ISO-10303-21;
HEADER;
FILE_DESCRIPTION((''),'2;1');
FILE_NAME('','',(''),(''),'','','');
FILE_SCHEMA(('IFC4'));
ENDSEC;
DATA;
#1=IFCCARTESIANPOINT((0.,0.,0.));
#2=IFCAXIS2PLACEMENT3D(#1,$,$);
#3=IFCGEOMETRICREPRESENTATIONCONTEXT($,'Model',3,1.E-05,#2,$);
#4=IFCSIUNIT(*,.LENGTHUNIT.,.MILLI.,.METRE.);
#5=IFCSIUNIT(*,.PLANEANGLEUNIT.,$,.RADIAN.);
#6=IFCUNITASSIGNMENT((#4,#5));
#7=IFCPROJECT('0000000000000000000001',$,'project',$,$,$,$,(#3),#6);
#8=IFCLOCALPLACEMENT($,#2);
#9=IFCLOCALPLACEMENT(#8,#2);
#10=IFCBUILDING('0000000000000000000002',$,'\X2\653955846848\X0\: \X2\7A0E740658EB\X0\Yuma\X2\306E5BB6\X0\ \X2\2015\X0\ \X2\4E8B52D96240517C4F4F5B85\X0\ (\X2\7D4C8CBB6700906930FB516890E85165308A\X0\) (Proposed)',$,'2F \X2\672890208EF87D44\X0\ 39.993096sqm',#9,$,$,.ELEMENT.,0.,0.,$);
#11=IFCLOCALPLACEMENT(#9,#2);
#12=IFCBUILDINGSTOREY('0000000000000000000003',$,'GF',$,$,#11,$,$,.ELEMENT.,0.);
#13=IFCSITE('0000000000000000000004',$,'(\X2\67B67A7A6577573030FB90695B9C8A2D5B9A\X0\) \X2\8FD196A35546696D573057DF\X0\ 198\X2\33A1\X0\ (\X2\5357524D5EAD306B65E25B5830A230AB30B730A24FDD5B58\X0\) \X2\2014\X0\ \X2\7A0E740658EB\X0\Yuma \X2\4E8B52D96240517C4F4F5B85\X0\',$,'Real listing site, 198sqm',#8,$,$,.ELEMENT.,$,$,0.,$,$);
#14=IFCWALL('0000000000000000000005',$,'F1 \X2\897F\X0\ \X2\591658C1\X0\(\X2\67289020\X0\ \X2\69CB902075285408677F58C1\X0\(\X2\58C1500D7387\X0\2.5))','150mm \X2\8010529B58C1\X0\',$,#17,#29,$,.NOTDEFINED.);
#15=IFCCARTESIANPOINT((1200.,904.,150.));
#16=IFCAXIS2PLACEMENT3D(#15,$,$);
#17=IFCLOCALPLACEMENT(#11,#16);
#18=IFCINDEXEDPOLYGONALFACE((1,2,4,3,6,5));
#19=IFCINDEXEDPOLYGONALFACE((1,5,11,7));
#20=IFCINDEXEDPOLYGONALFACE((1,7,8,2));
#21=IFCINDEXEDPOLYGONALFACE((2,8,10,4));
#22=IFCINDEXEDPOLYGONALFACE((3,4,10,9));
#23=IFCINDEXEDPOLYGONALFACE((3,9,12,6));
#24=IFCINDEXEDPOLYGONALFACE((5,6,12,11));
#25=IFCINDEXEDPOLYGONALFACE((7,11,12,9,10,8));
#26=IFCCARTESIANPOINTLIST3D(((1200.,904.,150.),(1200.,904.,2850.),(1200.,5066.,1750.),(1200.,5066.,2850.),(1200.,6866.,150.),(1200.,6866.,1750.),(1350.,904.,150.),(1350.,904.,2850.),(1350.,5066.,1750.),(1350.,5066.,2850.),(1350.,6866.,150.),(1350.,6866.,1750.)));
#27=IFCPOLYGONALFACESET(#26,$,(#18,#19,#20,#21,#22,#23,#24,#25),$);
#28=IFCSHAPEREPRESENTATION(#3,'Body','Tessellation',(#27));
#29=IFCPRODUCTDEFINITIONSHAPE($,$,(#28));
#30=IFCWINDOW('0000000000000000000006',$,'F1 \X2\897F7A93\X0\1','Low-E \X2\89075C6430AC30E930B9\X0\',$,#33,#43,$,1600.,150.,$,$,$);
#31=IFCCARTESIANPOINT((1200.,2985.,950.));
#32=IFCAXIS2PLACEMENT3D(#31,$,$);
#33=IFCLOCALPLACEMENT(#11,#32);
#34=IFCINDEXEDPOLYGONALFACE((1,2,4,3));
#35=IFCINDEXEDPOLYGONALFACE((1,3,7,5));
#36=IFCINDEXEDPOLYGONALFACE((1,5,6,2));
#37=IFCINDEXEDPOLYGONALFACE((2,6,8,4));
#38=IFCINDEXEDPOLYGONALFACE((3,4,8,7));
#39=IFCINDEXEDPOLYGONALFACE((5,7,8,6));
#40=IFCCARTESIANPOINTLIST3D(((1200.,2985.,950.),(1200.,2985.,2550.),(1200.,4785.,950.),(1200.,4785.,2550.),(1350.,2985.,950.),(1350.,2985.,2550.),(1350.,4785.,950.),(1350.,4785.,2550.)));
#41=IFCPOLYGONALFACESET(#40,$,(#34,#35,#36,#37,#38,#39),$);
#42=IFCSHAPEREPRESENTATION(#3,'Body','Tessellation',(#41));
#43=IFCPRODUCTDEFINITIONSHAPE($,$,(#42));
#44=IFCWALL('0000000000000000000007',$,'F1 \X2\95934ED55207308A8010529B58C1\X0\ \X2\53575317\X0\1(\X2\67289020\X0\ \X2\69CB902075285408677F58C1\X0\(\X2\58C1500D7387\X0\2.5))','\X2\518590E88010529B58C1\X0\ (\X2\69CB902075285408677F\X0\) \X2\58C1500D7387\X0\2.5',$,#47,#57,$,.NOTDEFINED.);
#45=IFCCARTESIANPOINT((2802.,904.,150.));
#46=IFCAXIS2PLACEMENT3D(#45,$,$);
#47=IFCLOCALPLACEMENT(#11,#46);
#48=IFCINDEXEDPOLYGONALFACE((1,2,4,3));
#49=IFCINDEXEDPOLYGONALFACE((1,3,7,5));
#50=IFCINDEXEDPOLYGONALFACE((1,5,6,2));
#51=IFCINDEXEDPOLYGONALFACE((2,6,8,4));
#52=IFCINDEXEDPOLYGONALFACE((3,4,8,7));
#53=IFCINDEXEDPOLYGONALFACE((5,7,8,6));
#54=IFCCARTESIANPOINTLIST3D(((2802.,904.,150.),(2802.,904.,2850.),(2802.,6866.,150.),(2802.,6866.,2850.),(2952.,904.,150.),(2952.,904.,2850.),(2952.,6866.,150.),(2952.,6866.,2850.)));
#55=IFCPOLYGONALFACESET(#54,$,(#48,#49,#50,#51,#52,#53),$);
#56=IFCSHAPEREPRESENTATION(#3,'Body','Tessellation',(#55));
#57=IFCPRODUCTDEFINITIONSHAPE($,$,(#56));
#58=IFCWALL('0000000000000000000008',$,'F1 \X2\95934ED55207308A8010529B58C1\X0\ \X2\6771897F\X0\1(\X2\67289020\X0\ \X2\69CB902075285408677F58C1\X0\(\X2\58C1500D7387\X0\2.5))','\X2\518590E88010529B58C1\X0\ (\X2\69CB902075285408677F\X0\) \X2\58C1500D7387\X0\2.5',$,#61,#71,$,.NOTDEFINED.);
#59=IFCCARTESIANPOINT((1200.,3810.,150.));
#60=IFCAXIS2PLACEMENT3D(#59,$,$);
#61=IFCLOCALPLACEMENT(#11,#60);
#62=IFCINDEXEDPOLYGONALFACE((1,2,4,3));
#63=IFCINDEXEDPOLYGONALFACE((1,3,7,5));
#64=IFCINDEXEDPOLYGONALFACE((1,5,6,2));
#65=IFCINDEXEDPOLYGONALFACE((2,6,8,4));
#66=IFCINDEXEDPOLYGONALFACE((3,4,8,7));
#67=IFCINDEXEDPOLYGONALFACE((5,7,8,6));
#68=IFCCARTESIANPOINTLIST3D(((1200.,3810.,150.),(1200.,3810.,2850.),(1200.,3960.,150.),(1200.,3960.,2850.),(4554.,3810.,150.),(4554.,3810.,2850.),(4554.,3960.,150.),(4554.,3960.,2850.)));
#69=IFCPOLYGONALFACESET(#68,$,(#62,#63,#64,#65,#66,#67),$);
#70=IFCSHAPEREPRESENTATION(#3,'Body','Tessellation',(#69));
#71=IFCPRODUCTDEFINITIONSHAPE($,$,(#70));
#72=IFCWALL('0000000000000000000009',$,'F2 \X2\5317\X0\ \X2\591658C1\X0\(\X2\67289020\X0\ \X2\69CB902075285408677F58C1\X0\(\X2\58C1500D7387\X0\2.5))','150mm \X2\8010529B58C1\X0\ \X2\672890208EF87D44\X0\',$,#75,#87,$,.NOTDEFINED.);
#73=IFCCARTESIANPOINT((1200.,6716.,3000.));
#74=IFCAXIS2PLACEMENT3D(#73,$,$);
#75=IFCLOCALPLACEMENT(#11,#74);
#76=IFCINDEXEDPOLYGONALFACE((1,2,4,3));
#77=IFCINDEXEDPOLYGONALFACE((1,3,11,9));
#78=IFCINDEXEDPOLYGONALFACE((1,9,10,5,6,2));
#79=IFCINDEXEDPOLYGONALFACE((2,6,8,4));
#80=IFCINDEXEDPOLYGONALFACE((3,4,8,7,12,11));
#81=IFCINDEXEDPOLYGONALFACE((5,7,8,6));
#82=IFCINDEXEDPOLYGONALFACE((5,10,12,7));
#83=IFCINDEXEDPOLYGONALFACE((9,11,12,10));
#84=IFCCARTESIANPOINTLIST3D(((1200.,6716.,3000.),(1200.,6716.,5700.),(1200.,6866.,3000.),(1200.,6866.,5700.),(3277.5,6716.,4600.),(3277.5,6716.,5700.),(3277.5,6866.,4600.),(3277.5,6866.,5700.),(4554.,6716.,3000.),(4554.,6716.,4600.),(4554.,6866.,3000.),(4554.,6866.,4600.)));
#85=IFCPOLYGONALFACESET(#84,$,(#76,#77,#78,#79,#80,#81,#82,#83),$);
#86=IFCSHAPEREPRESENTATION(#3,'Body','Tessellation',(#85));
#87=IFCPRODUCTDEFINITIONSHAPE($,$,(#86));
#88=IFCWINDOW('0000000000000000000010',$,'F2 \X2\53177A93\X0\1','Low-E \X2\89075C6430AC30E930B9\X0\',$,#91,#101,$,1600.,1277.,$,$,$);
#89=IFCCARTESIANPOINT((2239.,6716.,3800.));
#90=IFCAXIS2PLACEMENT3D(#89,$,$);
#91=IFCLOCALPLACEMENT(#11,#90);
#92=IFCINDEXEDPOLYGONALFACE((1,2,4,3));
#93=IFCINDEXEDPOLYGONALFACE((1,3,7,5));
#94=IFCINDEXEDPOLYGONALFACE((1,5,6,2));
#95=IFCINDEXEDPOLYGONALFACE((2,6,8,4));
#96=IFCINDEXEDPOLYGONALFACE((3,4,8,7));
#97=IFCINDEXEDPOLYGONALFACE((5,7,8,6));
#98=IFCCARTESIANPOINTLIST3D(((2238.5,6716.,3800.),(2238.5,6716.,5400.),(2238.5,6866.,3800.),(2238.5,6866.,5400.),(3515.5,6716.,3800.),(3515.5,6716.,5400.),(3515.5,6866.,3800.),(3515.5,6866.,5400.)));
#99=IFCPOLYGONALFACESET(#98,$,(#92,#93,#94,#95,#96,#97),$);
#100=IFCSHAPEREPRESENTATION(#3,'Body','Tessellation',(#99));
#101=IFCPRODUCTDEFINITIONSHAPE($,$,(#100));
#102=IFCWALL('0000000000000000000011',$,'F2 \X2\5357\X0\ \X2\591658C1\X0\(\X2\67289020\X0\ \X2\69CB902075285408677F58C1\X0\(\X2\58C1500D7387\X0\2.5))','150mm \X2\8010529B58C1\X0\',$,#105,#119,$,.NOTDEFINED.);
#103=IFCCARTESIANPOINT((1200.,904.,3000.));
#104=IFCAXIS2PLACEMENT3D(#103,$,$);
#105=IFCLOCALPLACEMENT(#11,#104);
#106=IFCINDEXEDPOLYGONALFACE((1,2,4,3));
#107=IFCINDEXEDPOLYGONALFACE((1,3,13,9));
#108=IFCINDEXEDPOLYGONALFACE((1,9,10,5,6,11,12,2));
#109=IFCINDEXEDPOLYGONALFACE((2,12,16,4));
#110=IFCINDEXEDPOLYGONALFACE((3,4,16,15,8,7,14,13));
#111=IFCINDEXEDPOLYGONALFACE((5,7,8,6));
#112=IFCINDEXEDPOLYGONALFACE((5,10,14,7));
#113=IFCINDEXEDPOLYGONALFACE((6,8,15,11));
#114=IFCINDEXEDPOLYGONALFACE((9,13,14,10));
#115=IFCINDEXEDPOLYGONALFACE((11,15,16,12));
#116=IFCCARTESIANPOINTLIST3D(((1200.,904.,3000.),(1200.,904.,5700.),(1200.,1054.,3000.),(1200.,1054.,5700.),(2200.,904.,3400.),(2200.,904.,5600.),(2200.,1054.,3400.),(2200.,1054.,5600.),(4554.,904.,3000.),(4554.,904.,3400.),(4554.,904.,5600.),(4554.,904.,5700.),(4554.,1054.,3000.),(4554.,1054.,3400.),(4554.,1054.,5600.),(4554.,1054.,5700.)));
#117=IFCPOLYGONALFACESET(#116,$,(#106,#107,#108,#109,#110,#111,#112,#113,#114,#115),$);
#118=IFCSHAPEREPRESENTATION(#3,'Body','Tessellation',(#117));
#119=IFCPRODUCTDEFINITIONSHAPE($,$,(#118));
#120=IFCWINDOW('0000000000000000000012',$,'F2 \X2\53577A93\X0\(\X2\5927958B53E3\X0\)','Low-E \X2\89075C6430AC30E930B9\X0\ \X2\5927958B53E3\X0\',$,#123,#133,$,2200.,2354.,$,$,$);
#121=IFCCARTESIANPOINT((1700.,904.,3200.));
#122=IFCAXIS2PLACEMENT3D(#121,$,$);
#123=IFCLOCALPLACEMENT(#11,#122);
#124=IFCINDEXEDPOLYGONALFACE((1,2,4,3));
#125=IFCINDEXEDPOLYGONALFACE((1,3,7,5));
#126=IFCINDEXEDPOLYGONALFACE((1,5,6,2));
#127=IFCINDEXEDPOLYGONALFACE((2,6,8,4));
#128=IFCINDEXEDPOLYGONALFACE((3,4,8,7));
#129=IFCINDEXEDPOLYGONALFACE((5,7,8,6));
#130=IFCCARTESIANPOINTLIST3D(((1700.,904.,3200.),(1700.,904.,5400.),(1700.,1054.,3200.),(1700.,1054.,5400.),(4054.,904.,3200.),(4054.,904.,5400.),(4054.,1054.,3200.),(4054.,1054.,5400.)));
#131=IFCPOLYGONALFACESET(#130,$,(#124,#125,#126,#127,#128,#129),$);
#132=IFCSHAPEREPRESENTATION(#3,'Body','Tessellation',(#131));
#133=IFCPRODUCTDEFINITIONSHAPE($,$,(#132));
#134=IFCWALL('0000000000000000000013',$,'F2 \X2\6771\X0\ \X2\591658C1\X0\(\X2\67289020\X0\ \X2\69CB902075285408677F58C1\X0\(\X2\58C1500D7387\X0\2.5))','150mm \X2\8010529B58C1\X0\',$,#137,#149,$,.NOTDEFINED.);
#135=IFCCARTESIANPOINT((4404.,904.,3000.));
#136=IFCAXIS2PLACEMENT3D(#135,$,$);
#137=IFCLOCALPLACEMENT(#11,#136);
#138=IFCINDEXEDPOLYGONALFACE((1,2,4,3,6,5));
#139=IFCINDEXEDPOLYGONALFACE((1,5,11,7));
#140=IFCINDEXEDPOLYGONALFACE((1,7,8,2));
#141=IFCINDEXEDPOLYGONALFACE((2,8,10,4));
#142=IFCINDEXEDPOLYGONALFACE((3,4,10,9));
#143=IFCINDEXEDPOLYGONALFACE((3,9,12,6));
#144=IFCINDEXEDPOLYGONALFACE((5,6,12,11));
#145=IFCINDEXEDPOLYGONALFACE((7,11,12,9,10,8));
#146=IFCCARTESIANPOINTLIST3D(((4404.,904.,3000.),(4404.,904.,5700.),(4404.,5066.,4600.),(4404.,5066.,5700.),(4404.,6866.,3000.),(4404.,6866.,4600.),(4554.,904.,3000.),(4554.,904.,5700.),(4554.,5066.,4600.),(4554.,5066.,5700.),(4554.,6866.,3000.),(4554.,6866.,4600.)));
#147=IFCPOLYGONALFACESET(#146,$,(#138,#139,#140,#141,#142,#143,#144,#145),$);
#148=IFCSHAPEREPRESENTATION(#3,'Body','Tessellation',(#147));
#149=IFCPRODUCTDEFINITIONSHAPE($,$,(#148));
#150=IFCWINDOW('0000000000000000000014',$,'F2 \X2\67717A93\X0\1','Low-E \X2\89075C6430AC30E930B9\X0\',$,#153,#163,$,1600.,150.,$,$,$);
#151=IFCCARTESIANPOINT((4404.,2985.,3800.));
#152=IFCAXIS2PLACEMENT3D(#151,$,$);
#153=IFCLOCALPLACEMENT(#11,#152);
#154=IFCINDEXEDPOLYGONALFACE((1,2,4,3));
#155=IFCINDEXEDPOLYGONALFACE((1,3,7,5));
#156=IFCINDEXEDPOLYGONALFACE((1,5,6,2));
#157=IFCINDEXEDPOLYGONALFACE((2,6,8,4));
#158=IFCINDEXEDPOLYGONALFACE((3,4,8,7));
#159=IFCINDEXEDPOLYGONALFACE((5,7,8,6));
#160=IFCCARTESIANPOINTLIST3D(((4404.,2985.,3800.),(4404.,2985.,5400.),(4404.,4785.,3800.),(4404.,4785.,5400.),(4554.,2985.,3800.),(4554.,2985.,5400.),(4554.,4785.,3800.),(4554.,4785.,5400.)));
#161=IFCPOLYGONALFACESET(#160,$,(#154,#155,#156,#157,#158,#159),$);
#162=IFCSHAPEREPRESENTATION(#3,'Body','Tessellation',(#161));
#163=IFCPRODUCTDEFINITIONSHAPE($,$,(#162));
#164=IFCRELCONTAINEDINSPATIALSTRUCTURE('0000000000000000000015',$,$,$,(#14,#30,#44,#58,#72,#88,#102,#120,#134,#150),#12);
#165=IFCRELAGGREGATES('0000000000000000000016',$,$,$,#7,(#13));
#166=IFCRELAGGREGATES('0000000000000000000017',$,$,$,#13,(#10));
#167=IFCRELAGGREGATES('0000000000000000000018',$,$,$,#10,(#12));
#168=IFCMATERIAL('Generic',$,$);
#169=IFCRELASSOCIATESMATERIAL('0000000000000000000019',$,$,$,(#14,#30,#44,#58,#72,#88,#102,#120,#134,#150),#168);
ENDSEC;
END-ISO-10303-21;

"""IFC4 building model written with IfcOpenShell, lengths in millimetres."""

from ifc_helpers import new_model, si_unit, frame, frame_2d, origin, place, context, project, spatial, rectangle, extrude, material, element, fill, save


model = new_model("IFC4")

# Units and contexts
model_context = context("Model", 3, precision=1e-05, world=origin())
ifc_project = project(units=[si_unit("LENGTHUNIT", "METRE", prefix="MILLI"), si_unit("PLANEANGLEUNIT", "RADIAN")], contexts=[model_context])

# Site, building, storey
site_placement = place(None, origin())
site = spatial("IfcSite", under=ifc_project, at=site_placement, Name="(架空敷地・適宜設定) 近隣商業地域 198㎡ (南前庭に既存アカシア保存) — 税理士Yuma 事務所兼住宅", ObjectType="Real listing site, 198sqm", CompositionType="ELEMENT", RefElevation=0.0)
building_placement = place(site_placement, origin())
building = spatial("IfcBuilding", under=site, at=building_placement, Name="改善案: 税理士Yumaの家 ― 事務所兼住宅 (経費最適・全部入り) (Proposed)", ObjectType="2F 木造軸組 39.993096sqm", CompositionType="ELEMENT", ElevationOfRefHeight=0.0, ElevationOfTerrain=0.0)
storey_placement = place(building_placement, origin())
storey = spatial("IfcBuildingStorey", under=building, at=storey_placement, Name="GF", CompositionType="ELEMENT", Elevation=0.0)

# Shared definitions
ifc_material_1 = material(Name="Generic")

# Wall, opening, window
wall_1_placement = place(storey_placement, frame((1200.0, 904.0, 150.0)))
wall_1 = element("IfcWall", 1, at=wall_1_placement, inside=storey, material=ifc_material_1, Name="F1 西 外壁(木造 構造用合板壁(壁倍率2.5))", Description="150mm 耐力壁", PredefinedType="NOTDEFINED", context=model_context, shape_type="SweptSolid", body=[
    extrude(rectangle(XDim=150.0, YDim=5962.0, at=frame_2d((75.0, 2981.0))), frame((1200.0, 904.0, 150.0)), (0.0, 0.0, 1.0), 2700.0),
])
opening_1_placement = place(storey_placement, frame((1200.0, 2985.0, 950.0)))
opening_1 = element("IfcOpeningElement", 2, at=opening_1_placement, cuts=wall_1, PredefinedType="NOTDEFINED", context=model_context, shape_type="SweptSolid", body=[
    extrude(rectangle(XDim=150.0, YDim=1800.0, at=frame_2d((75.0, 900.0))), frame((1200.0, 2985.0, 950.0)), (0.0, 0.0, 1.0), 1600.0),
])
window_1_placement = place(storey_placement, frame((1200.0, 2985.0, 950.0)))
window_1 = element("IfcWindow", 3, at=window_1_placement, inside=storey, material=ifc_material_1, Name="F1 西窓1", Description="Low-E 複層ガラス", OverallHeight=1600.0, OverallWidth=150.0, context=model_context, shape_type="SweptSolid", body=[
    extrude(rectangle(XDim=150.0, YDim=1800.0, at=frame_2d((75.0, 900.0))), frame((1200.0, 2985.0, 950.0)), (0.0, 0.0, 1.0), 1600.0),
])
fill(opening_1, window_1)

# Walls
wall_2_placement = place(storey_placement, frame((2802.0, 904.0, 150.0)))
element("IfcWall", 4, at=wall_2_placement, inside=storey, material=ifc_material_1, Name="F1 間仕切り耐力壁 南北1(木造 構造用合板壁(壁倍率2.5))", Description="内部耐力壁 (構造用合板) 壁倍率2.5", PredefinedType="NOTDEFINED", context=model_context, shape_type="SweptSolid", body=[
    extrude(rectangle(XDim=150.0, YDim=5962.0, at=frame_2d((75.0, 2981.0))), frame((2802.0, 904.0, 150.0)), (0.0, 0.0, 1.0), 2700.0),
])
wall_3_placement = place(storey_placement, frame((1200.0, 3810.0, 150.0)))
element("IfcWall", 5, at=wall_3_placement, inside=storey, material=ifc_material_1, Name="F1 間仕切り耐力壁 東西1(木造 構造用合板壁(壁倍率2.5))", Description="内部耐力壁 (構造用合板) 壁倍率2.5", PredefinedType="NOTDEFINED", context=model_context, shape_type="SweptSolid", body=[
    extrude(rectangle(XDim=3354.0, YDim=150.0, at=frame_2d((1677.0, 75.0))), frame((1200.0, 3810.0, 150.0)), (0.0, 0.0, 1.0), 2700.0),
])

# Walls, openings, windows
wall_4_placement = place(storey_placement, frame((1200.0, 6716.0, 3000.0)))
wall_4 = element("IfcWall", 6, at=wall_4_placement, inside=storey, material=ifc_material_1, Name="F2 北 外壁(木造 構造用合板壁(壁倍率2.5))", Description="150mm 耐力壁 木造軸組", PredefinedType="NOTDEFINED", context=model_context, shape_type="SweptSolid", body=[
    extrude(rectangle(XDim=3354.0, YDim=150.0, at=frame_2d((1677.0, 75.0))), frame((1200.0, 6716.0, 3000.0)), (0.0, 0.0, 1.0), 2700.0),
])
opening_2_placement = place(storey_placement, frame((2239.0, 6716.0, 3800.0)))
opening_2 = element("IfcOpeningElement", 7, at=opening_2_placement, cuts=wall_4, PredefinedType="NOTDEFINED", context=model_context, shape_type="SweptSolid", body=[
    extrude(rectangle(XDim=1277.0, YDim=150.0, at=frame_2d((638.0, 75.0))), frame((2239.0, 6716.0, 3800.0)), (0.0, 0.0, 1.0), 1600.0),
])
window_2_placement = place(storey_placement, frame((2239.0, 6716.0, 3800.0)))
window_2 = element("IfcWindow", 8, at=window_2_placement, inside=storey, material=ifc_material_1, Name="F2 北窓1", Description="Low-E 複層ガラス", OverallHeight=1600.0, OverallWidth=1277.0, context=model_context, shape_type="SweptSolid", body=[
    extrude(rectangle(XDim=1277.0, YDim=150.0, at=frame_2d((638.0, 75.0))), frame((2239.0, 6716.0, 3800.0)), (0.0, 0.0, 1.0), 1600.0),
])
fill(opening_2, window_2)
wall_5_placement = place(storey_placement, frame((1200.0, 904.0, 3000.0)))
wall_5 = element("IfcWall", 9, at=wall_5_placement, inside=storey, material=ifc_material_1, Name="F2 南 外壁(木造 構造用合板壁(壁倍率2.5))", Description="150mm 耐力壁", PredefinedType="NOTDEFINED", context=model_context, shape_type="SweptSolid", body=[
    extrude(rectangle(XDim=3354.0, YDim=150.0, at=frame_2d((1677.0, 75.0))), frame((1200.0, 904.0, 3000.0)), (0.0, 0.0, 1.0), 2700.0),
])
opening_3_placement = place(storey_placement, frame((1700.0, 904.0, 3200.0)))
opening_3 = element("IfcOpeningElement", 10, at=opening_3_placement, cuts=wall_5, PredefinedType="NOTDEFINED", context=model_context, shape_type="SweptSolid", body=[
    extrude(rectangle(XDim=2354.0, YDim=150.0, at=frame_2d((1177.0, 75.0))), frame((1700.0, 904.0, 3200.0)), (0.0, 0.0, 1.0), 2200.0),
])
window_3_placement = place(storey_placement, frame((1700.0, 904.0, 3200.0)))
window_3 = element("IfcWindow", 11, at=window_3_placement, inside=storey, material=ifc_material_1, Name="F2 南窓(大開口)", Description="Low-E 複層ガラス 大開口", OverallHeight=2200.0, OverallWidth=2354.0, context=model_context, shape_type="SweptSolid", body=[
    extrude(rectangle(XDim=2354.0, YDim=150.0, at=frame_2d((1177.0, 75.0))), frame((1700.0, 904.0, 3200.0)), (0.0, 0.0, 1.0), 2200.0),
])
fill(opening_3, window_3)
wall_6_placement = place(storey_placement, frame((4404.0, 904.0, 3000.0)))
wall_6 = element("IfcWall", 12, at=wall_6_placement, inside=storey, material=ifc_material_1, Name="F2 東 外壁(木造 構造用合板壁(壁倍率2.5))", Description="150mm 耐力壁", PredefinedType="NOTDEFINED", context=model_context, shape_type="SweptSolid", body=[
    extrude(rectangle(XDim=150.0, YDim=5962.0, at=frame_2d((75.0, 2981.0))), frame((4404.0, 904.0, 3000.0)), (0.0, 0.0, 1.0), 2700.0),
])
opening_4_placement = place(storey_placement, frame((4404.0, 2985.0, 3800.0)))
opening_4 = element("IfcOpeningElement", 13, at=opening_4_placement, cuts=wall_6, PredefinedType="NOTDEFINED", context=model_context, shape_type="SweptSolid", body=[
    extrude(rectangle(XDim=150.0, YDim=1800.0, at=frame_2d((75.0, 900.0))), frame((4404.0, 2985.0, 3800.0)), (0.0, 0.0, 1.0), 1600.0),
])
window_4_placement = place(storey_placement, frame((4404.0, 2985.0, 3800.0)))
window_4 = element("IfcWindow", 14, at=window_4_placement, inside=storey, material=ifc_material_1, Name="F2 東窓1", Description="Low-E 複層ガラス", OverallHeight=1600.0, OverallWidth=150.0, context=model_context, shape_type="SweptSolid", body=[
    extrude(rectangle(XDim=150.0, YDim=1800.0, at=frame_2d((75.0, 900.0))), frame((4404.0, 2985.0, 3800.0)), (0.0, 0.0, 1.0), 1600.0),
])
fill(opening_4, window_4)

save(model, "model.ifc")
